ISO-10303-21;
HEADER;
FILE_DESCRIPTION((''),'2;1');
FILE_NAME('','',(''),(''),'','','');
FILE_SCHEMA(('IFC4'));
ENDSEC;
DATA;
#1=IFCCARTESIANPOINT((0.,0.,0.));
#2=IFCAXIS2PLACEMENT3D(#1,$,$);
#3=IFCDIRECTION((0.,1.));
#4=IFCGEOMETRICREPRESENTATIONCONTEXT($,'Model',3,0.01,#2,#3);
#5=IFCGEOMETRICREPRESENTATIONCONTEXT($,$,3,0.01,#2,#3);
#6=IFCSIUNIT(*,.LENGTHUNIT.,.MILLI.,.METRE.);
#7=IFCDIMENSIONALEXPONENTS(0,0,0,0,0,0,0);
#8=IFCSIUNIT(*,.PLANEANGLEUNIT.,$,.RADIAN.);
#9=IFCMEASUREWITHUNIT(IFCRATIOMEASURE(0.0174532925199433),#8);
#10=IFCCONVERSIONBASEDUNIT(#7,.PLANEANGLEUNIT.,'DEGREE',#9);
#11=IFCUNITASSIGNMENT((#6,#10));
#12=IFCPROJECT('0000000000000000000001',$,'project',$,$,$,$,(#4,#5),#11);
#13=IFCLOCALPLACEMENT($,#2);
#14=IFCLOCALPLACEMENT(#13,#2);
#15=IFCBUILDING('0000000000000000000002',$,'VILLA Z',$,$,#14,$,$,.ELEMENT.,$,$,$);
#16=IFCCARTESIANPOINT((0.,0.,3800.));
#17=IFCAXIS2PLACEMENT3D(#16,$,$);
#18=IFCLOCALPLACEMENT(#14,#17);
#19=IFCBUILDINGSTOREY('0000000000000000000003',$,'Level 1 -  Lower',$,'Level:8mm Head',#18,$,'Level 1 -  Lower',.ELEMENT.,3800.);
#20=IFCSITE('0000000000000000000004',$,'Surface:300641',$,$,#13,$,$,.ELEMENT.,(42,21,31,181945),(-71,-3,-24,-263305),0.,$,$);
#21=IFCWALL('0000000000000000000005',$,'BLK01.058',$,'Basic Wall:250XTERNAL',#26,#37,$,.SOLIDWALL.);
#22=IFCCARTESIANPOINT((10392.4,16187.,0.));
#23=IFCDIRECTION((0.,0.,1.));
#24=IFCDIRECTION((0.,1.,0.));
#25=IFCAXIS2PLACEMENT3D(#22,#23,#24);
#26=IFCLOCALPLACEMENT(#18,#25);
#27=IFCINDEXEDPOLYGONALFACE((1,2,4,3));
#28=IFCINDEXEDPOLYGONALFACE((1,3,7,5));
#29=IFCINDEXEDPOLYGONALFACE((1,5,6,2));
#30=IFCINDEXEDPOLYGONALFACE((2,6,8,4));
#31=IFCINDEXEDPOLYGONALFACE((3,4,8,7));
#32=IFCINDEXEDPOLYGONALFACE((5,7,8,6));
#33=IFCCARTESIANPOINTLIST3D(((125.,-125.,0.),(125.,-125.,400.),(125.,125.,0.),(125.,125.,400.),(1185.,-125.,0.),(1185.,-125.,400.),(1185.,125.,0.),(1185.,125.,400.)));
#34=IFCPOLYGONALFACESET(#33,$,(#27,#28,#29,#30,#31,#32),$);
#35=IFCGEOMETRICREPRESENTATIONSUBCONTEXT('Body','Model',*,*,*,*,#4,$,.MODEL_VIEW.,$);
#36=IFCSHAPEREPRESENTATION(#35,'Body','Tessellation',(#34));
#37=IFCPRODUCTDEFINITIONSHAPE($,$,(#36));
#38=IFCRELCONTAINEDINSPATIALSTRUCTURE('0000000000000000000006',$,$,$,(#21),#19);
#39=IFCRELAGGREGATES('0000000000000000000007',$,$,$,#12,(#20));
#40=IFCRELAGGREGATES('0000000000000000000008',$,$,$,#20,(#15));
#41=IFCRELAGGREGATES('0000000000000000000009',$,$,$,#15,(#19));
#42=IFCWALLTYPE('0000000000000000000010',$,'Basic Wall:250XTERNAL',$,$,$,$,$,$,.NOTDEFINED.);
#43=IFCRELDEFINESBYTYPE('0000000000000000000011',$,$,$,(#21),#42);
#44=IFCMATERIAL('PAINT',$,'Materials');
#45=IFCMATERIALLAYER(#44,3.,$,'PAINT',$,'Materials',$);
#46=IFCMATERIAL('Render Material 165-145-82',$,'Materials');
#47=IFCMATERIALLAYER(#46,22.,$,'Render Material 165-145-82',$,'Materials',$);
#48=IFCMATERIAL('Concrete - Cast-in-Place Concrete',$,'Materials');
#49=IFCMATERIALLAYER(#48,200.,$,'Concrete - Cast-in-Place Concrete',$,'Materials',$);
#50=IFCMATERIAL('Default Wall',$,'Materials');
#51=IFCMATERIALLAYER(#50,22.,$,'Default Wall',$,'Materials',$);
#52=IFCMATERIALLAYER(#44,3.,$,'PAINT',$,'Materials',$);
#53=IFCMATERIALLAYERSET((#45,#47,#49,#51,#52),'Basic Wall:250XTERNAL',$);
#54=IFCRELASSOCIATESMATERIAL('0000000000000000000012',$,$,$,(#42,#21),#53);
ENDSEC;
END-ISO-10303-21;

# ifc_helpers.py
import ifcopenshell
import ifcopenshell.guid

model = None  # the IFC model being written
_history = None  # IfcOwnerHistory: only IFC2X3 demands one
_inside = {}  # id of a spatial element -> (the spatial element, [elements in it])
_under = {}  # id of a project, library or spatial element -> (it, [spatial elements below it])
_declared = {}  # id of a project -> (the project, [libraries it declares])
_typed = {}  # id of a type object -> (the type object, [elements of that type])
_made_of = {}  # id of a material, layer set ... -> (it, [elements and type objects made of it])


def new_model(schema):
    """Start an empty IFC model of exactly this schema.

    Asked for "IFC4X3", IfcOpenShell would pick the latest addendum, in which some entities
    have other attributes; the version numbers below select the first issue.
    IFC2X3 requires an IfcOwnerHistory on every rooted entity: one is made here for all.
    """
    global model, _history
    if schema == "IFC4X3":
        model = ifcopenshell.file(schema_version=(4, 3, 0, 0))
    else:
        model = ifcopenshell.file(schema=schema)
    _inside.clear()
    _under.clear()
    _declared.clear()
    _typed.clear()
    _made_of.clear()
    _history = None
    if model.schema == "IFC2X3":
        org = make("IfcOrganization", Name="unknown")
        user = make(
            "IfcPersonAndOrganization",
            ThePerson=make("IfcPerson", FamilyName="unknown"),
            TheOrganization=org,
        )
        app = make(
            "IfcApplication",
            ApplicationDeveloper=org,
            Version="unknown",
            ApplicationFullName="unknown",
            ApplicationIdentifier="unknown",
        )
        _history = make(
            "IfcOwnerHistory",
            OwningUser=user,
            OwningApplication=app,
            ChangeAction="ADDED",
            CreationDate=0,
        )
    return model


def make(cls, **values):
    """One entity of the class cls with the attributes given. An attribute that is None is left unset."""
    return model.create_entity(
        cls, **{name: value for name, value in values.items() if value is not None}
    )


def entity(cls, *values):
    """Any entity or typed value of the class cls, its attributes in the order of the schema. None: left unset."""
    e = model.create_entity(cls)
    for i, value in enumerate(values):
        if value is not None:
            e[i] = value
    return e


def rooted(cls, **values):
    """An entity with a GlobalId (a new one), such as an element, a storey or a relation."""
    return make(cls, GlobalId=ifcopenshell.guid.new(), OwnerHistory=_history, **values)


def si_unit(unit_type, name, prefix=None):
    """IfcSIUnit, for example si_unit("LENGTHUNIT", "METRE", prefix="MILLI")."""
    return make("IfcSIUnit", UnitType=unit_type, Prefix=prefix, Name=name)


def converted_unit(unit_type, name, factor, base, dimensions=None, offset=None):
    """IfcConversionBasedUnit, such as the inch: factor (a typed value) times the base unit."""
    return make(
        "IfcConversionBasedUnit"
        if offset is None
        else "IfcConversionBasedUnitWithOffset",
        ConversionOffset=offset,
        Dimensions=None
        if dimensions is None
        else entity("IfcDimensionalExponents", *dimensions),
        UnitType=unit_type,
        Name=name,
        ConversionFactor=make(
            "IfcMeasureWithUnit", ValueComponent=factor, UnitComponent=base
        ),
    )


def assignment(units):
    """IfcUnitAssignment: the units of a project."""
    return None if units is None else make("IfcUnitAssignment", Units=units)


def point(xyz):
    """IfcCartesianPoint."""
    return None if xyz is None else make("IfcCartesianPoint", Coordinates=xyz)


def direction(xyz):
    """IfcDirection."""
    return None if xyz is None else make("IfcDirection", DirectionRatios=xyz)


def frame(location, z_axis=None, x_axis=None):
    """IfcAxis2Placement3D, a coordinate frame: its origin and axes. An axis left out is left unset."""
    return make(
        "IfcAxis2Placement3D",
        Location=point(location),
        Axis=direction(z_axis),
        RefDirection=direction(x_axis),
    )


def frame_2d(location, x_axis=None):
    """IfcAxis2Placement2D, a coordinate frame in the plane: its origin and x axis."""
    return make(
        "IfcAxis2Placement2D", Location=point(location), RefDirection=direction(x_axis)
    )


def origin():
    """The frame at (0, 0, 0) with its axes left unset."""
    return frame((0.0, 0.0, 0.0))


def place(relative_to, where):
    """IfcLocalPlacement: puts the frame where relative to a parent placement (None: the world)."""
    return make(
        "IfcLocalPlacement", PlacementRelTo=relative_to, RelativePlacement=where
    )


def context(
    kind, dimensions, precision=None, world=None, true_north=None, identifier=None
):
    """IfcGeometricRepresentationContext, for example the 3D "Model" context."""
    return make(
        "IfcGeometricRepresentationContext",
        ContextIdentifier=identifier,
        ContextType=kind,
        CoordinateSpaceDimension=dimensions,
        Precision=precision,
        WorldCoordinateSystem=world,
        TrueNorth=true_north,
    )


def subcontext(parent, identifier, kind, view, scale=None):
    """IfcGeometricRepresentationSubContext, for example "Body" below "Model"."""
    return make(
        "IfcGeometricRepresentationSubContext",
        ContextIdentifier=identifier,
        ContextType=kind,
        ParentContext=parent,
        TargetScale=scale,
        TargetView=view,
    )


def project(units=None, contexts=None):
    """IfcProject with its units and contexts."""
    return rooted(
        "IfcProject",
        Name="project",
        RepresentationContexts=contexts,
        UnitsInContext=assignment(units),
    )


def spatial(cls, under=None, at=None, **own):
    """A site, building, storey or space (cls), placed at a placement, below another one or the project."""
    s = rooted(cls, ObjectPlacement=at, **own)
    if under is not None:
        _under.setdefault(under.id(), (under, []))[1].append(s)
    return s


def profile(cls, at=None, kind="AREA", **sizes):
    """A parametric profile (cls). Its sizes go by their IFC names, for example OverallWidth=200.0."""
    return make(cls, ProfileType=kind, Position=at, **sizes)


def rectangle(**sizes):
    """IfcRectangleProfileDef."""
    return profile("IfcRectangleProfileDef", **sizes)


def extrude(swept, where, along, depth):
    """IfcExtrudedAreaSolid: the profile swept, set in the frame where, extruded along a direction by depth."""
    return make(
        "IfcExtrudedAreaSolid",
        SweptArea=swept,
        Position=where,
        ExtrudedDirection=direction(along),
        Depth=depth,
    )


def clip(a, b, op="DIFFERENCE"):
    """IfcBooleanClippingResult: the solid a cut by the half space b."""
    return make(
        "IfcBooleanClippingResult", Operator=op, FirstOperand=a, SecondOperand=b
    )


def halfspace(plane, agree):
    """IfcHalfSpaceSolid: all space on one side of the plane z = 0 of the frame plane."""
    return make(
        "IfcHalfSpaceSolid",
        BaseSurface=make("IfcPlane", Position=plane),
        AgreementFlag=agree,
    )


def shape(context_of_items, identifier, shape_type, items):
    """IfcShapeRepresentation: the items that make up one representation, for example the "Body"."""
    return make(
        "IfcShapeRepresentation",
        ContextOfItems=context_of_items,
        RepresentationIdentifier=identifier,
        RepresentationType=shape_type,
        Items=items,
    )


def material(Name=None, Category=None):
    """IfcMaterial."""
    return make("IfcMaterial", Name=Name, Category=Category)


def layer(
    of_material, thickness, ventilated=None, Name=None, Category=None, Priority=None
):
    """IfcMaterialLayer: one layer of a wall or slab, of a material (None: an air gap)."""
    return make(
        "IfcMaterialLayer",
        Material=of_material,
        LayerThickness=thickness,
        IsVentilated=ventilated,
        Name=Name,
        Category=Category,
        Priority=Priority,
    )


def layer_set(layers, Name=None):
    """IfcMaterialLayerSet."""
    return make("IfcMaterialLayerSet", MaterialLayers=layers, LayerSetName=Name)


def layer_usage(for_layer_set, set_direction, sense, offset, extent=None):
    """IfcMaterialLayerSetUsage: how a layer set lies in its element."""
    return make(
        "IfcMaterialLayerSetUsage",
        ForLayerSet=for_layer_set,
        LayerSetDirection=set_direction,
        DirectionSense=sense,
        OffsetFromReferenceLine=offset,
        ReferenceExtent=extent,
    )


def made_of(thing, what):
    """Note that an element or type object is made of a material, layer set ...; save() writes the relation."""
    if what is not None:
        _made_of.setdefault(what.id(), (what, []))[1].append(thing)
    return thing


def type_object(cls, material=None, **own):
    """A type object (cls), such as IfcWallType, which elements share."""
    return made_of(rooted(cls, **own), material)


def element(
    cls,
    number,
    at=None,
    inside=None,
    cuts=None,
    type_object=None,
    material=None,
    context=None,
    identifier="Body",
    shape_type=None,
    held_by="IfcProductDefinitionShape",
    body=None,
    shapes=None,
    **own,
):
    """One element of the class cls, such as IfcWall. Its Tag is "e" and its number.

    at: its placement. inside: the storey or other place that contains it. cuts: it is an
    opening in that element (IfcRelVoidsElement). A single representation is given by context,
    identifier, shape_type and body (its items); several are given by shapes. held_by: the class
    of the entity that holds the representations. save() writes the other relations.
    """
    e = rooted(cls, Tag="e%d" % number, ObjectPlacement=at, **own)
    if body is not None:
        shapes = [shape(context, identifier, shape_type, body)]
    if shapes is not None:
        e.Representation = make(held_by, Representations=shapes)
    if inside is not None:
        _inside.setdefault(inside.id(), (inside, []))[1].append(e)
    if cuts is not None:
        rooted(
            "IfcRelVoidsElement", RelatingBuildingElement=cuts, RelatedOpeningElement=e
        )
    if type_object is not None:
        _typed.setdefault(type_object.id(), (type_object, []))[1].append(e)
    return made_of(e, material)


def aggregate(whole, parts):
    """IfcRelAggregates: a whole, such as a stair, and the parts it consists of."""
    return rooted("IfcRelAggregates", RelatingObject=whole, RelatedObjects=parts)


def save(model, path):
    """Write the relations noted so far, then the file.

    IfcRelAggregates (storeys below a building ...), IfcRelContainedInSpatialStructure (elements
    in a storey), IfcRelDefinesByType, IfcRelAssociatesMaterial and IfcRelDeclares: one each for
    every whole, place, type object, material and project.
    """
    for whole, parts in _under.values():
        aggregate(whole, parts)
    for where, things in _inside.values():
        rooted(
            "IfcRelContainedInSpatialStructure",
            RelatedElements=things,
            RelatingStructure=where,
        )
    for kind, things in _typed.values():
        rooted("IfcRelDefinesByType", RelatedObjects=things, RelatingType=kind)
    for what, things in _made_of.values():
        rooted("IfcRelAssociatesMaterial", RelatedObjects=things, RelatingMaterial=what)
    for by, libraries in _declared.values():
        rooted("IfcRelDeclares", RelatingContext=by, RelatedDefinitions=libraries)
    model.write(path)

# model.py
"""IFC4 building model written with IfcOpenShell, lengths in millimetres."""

from ifc_helpers import new_model, entity, si_unit, converted_unit, direction, frame, frame_2d, origin, place, context, subcontext, project, spatial, rectangle, extrude, clip, halfspace, material, layer, layer_set, layer_usage, type_object, element, save


model = new_model("IFC4")

# Units and contexts
model_context = context("Model", 3, precision=0.01, world=origin(), true_north=direction((0.0, 1.0)))
context_of_model = context(None, 3, precision=0.01, world=origin(), true_north=direction((0.0, 1.0)))
body_context = subcontext(model_context, "Body", "Model", "MODEL_VIEW")
ifc_project = project(units=[si_unit("LENGTHUNIT", "METRE", prefix="MILLI"), converted_unit("PLANEANGLEUNIT", "DEGREE", entity("IfcRatioMeasure", 0.0174532925199433), si_unit("PLANEANGLEUNIT", "RADIAN"), dimensions=[0, 0, 0, 0, 0, 0, 0])], contexts=[model_context, context_of_model])

# Site, building, storey
site_placement = place(None, origin())
site = spatial("IfcSite", under=ifc_project, at=site_placement, Name="Surface:300641", CompositionType="ELEMENT", RefLatitude=(42, 21, 31, 181945), RefLongitude=(-71, -3, -24, -263305), RefElevation=0.0)
building_placement = place(site_placement, origin())
building = spatial("IfcBuilding", under=site, at=building_placement, Name="VILLA Z", CompositionType="ELEMENT")
storey_placement = place(building_placement, frame((0.0, 0.0, 3800.0)))
storey = spatial("IfcBuildingStorey", under=building, at=storey_placement, Name="Level 1 -  Lower", ObjectType="Level:8mm Head", LongName="Level 1 -  Lower", CompositionType="ELEMENT", Elevation=3800.0)

# Shared definitions
ifc_material_1 = material(Name="Concrete - Cast-in-Place Concrete", Category="Materials")

# Wall
ifc_material_2 = material(Name="PAINT", Category="Materials")
ifc_layer_1 = layer(ifc_material_2, 3.0, Name="PAINT", Category="Materials")
ifc_material_3 = material(Name="Render Material 165-145-82", Category="Materials")
ifc_layer_2 = layer(ifc_material_3, 22.0, Name="Render Material 165-145-82", Category="Materials")
ifc_layer_3 = layer(ifc_material_1, 200.0, Name="Concrete - Cast-in-Place Concrete", Category="Materials")
ifc_material_4 = material(Name="Default Wall", Category="Materials")
ifc_layer_4 = layer(ifc_material_4, 22.0, Name="Default Wall", Category="Materials")
ifc_layer_5 = layer(ifc_material_2, 3.0, Name="PAINT", Category="Materials")
ifc_layer_set_1 = layer_set([ifc_layer_1, ifc_layer_2, ifc_layer_3, ifc_layer_4, ifc_layer_5], Name="Basic Wall:250XTERNAL")
wall_type_1 = type_object("IfcWallType", Name="Basic Wall:250XTERNAL", PredefinedType="NOTDEFINED", material=ifc_layer_set_1)
ifc_layer_usage_1 = layer_usage(ifc_layer_set_1, "AXIS2", "NEGATIVE", 125.0)
wall_1_placement = place(storey_placement, frame((10392.4, 16187.0, 0.0), z_axis=(0.0, 0.0, 1.0), x_axis=(0.0, 1.0, 0.0)))
element("IfcWall", 1, at=wall_1_placement, inside=storey, type_object=wall_type_1, material=ifc_layer_usage_1, Name="BLK01.058", ObjectType="Basic Wall:250XTERNAL", PredefinedType="SOLIDWALL", context=body_context, shape_type="Clipping", body=[
    clip(extrude(rectangle(XDim=1060.0, YDim=250.0, at=frame_2d((655.0, 0.0), x_axis=(-1.0, 0.0))), origin(), (0.0, 0.0, 1.0), 400.0), halfspace(origin(), True)),
])

save(model, "model.ifc")
